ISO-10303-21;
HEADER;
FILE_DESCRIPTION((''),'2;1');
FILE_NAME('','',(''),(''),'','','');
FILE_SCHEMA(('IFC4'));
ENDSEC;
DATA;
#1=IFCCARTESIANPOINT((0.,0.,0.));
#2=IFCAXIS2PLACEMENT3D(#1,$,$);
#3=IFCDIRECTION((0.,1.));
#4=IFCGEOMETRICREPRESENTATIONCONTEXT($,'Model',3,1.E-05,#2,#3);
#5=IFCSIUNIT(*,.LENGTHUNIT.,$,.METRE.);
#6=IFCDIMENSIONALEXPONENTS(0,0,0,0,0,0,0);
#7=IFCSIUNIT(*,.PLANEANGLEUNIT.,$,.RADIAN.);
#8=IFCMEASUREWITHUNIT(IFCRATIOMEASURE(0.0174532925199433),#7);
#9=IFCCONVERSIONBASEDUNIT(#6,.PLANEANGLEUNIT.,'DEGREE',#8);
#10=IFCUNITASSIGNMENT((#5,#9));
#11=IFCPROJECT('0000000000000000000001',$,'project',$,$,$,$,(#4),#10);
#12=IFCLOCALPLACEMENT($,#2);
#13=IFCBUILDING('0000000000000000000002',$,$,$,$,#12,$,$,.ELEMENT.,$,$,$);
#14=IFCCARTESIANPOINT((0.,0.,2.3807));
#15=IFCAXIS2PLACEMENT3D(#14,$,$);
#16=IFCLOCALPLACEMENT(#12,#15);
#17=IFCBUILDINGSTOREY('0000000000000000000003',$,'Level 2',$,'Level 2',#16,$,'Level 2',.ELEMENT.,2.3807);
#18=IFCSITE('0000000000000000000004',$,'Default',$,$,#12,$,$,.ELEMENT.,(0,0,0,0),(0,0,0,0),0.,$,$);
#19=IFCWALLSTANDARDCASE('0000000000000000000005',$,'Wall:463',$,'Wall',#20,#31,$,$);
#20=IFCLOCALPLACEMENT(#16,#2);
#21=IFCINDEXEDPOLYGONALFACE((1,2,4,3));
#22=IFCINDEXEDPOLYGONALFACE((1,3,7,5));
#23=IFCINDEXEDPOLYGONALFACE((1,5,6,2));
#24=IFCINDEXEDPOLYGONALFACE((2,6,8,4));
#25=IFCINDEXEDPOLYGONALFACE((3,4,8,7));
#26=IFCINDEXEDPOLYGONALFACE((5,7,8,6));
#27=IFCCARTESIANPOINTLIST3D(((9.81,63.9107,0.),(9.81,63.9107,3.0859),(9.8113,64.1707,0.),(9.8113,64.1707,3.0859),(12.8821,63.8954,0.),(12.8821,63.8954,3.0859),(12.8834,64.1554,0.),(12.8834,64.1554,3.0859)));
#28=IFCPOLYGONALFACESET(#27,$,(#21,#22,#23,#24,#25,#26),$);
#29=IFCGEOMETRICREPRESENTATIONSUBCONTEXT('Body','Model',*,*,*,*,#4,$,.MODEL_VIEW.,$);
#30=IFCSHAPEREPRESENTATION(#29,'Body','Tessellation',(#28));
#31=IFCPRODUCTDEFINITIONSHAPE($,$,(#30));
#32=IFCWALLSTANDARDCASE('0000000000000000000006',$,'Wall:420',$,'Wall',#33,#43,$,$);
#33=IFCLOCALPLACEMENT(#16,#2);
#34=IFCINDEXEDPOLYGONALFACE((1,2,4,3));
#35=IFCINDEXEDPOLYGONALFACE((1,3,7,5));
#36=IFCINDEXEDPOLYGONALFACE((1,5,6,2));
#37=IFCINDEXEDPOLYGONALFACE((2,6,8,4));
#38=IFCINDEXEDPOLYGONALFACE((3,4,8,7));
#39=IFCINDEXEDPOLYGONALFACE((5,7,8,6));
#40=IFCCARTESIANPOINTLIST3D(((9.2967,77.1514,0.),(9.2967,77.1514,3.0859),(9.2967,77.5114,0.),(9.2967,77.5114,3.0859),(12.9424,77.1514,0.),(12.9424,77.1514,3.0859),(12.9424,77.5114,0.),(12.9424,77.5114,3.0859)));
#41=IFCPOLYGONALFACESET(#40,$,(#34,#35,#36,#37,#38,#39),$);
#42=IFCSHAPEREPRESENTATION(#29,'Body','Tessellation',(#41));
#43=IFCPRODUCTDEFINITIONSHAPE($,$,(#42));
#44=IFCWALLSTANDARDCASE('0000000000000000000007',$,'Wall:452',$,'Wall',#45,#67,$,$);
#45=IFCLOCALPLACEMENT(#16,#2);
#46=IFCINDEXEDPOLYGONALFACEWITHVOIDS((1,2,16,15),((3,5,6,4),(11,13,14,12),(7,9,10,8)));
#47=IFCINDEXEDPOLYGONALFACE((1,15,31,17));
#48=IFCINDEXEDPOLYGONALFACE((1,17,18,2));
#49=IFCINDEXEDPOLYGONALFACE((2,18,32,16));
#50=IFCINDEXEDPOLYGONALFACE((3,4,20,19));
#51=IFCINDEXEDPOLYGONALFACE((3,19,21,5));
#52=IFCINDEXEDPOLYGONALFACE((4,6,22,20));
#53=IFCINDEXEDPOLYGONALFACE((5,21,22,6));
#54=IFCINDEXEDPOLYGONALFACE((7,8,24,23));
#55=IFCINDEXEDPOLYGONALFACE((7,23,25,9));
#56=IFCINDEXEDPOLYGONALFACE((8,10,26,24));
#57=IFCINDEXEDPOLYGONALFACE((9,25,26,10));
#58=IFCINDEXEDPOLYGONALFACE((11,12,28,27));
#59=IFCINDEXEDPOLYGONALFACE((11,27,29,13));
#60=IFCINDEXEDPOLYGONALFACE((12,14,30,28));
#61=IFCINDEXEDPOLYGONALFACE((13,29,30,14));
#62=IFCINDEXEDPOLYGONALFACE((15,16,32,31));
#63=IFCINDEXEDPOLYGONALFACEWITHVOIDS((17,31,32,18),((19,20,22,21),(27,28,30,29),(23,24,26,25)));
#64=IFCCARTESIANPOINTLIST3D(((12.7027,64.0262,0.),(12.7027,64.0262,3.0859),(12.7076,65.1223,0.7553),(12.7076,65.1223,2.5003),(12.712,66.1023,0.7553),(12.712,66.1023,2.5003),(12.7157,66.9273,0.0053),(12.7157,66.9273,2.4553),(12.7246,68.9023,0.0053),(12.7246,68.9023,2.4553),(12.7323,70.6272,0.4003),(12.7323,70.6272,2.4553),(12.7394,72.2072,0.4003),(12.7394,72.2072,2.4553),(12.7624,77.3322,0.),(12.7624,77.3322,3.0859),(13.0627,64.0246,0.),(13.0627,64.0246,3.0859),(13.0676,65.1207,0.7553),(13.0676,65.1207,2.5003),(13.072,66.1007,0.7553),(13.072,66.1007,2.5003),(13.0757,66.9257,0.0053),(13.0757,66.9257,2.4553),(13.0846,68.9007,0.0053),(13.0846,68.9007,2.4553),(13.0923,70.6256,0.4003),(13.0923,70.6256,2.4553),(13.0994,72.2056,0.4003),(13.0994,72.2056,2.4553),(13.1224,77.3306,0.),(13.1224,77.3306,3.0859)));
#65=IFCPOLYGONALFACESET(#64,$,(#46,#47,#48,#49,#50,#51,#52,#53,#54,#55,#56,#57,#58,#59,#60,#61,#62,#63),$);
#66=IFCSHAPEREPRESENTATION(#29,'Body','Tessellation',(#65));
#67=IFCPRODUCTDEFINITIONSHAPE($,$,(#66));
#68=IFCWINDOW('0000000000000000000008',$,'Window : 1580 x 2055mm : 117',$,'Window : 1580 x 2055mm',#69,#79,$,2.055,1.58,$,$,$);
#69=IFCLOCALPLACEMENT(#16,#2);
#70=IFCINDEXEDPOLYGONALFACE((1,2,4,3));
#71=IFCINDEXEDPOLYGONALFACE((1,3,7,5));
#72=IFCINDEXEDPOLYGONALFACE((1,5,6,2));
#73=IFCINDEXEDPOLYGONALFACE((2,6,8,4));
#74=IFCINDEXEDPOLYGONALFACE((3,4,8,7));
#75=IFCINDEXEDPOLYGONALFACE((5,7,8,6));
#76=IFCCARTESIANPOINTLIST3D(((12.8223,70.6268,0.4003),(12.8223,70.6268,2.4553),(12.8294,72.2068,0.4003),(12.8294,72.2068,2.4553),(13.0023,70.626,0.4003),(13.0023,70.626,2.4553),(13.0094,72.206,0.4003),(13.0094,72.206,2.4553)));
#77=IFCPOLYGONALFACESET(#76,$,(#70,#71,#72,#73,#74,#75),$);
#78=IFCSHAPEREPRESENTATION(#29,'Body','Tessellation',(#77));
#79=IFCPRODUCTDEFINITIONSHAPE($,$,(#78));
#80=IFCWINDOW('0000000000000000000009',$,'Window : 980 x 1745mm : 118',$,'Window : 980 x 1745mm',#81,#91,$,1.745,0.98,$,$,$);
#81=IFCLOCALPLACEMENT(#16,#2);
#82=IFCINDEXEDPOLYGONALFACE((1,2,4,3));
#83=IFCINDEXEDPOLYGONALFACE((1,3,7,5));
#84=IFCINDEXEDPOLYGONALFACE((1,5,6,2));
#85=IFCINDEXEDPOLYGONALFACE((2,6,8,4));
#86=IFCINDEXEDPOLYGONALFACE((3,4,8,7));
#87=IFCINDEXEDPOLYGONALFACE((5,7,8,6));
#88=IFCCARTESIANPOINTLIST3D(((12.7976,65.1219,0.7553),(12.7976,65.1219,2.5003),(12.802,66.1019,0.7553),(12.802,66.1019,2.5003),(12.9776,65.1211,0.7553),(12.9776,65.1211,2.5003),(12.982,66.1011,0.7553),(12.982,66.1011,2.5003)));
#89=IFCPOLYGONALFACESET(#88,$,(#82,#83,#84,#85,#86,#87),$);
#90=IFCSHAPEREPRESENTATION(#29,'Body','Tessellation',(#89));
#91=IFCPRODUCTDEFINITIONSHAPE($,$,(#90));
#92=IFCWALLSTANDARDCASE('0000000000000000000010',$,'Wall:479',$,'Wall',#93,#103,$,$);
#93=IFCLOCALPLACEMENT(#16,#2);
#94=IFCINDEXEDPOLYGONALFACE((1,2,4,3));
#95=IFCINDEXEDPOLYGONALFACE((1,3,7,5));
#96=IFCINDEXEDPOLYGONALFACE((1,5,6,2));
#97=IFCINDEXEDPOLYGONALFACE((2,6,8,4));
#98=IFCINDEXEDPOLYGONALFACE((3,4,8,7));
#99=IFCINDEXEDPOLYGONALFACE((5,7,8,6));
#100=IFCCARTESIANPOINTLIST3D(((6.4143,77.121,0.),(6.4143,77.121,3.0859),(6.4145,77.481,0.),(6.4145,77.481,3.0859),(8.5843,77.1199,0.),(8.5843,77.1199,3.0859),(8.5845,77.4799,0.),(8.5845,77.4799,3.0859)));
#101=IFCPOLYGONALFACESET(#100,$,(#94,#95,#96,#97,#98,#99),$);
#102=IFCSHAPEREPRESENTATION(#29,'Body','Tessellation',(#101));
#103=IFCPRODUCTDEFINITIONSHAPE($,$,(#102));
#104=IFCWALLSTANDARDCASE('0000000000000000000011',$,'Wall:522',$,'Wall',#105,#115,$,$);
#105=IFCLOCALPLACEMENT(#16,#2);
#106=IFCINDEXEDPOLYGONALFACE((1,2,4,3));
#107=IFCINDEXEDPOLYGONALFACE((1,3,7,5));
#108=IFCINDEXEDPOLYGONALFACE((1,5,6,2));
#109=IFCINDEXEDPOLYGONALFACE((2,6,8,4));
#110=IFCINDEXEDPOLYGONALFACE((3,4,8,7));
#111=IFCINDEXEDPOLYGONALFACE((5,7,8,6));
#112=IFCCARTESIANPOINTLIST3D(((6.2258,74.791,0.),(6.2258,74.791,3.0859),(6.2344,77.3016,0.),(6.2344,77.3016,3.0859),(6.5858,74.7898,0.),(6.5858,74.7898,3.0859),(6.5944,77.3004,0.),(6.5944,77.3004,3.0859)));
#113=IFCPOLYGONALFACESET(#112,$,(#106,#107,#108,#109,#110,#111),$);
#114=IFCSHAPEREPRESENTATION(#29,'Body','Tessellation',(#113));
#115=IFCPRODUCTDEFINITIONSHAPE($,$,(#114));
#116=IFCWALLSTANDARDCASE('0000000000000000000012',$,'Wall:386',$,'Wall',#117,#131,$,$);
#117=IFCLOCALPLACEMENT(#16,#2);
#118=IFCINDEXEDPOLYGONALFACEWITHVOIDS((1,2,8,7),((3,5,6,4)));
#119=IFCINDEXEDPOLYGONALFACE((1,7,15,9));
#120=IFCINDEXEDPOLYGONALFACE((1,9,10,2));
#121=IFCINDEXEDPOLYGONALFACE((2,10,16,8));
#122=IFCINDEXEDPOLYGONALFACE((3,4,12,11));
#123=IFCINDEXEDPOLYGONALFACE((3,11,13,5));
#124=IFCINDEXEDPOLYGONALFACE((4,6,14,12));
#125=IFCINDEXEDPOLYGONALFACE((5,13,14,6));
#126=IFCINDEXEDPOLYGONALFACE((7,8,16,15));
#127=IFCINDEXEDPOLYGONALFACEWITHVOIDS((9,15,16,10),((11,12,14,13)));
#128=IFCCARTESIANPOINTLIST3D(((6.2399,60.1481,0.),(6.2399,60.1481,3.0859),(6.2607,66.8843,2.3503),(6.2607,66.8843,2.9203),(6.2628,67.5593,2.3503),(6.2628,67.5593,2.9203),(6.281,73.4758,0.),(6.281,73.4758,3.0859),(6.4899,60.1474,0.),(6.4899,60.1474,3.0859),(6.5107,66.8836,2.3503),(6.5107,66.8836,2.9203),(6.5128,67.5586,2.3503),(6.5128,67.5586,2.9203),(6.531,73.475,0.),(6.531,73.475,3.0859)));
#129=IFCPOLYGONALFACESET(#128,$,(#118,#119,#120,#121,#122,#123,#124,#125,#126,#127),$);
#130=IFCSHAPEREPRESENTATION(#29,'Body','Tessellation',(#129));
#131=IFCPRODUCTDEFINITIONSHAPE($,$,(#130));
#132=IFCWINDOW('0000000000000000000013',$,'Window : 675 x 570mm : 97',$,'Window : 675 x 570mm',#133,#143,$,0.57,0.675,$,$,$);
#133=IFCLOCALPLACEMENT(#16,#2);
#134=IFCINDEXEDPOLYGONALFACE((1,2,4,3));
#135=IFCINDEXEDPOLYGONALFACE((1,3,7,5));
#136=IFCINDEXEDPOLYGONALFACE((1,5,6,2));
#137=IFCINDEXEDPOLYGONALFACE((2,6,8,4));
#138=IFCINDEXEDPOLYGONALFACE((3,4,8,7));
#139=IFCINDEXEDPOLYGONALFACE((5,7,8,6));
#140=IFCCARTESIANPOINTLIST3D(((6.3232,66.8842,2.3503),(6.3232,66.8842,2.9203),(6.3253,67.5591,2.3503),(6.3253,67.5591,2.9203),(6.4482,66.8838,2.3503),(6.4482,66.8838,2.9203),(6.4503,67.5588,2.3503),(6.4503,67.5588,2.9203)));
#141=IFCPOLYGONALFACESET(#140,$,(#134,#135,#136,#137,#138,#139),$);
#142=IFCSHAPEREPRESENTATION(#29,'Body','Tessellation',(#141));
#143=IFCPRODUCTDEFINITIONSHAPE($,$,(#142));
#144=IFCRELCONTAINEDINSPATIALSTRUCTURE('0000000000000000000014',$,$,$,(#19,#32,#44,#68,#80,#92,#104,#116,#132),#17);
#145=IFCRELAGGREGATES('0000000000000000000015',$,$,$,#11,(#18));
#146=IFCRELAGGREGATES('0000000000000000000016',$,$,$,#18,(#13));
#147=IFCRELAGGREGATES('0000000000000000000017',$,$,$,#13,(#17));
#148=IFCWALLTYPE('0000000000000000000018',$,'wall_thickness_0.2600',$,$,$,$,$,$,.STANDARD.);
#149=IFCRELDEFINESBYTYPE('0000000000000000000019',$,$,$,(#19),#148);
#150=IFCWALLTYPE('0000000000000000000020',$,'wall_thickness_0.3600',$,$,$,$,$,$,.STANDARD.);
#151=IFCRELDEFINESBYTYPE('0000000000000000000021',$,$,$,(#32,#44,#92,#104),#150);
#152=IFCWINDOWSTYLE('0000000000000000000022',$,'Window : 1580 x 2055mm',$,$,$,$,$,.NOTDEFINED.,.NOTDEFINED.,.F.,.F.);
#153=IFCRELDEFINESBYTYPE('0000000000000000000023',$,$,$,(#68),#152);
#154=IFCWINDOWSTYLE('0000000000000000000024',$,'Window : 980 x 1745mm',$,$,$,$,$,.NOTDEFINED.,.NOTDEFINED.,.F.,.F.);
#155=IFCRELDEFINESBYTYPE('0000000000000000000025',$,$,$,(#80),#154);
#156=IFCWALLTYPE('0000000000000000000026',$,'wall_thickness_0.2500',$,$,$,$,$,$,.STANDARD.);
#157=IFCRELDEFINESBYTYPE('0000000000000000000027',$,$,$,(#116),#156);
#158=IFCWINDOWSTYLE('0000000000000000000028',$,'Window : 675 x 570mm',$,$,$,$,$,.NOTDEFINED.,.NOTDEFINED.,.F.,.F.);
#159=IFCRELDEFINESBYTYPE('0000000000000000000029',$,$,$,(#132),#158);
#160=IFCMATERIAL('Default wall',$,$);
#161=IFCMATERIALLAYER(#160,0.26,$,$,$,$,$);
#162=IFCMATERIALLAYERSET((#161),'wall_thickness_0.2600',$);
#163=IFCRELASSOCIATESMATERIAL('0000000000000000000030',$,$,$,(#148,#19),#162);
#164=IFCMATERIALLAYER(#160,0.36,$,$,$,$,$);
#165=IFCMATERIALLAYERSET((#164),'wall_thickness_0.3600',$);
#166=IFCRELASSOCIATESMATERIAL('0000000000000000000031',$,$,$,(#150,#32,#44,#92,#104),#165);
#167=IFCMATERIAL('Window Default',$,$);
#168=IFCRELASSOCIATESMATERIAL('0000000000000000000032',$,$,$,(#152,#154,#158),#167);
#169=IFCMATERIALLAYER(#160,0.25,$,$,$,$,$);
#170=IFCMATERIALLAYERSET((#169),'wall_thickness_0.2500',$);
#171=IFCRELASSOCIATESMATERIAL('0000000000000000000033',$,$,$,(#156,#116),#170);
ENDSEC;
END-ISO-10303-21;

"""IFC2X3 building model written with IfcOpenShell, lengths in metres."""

from ifc_helpers import new_model, entity, si_unit, converted_unit, direction, frame, frame_2d, origin, origin_2d_with_axis, place, context, subcontext, project, spatial, polyline, rectangle, outline, extrude, source, transform, mapped, material, layer, layer_set, layer_usage, type_object, type_shapes, element, fill, save


model = new_model("IFC2X3")

# Units and contexts
model_context = context("Model", 3, precision=1e-05, world=origin(), true_north=direction((0.0, 1.0)))
body_context = subcontext(model_context, "Body", "Model", "MODEL_VIEW")
ifc_project = project(units=[si_unit("LENGTHUNIT", "METRE"), converted_unit("PLANEANGLEUNIT", "DEGREE", entity("IfcRatioMeasure", 0.0174532925199433), si_unit("PLANEANGLEUNIT", "RADIAN"), dimensions=[0, 0, 0, 0, 0, 0, 0])], contexts=[model_context])

# Site, building, storey
placement_1 = place(None, origin())
site = spatial("IfcSite", under=ifc_project, at=placement_1, Name="Default", CompositionType="ELEMENT", RefLatitude=(0, 0, 0, 0), RefLongitude=(0, 0, 0, 0), RefElevation=0.0)
building = spatial("IfcBuilding", under=site, at=placement_1, CompositionType="ELEMENT")
storey_placement = place(placement_1, frame((0.0, 0.0, 2.3807)))
storey = spatial("IfcBuildingStorey", under=building, at=storey_placement, Name="Level 2", ObjectType="Level 2", LongName="Level 2", CompositionType="ELEMENT", Elevation=2.3807)

# Walls
ifc_material_1 = material(Name="Default wall")
ifc_layer_1 = layer(ifc_material_1, 0.26)
ifc_layer_set_1 = layer_set([ifc_layer_1], Name="wall_thickness_0.2600")
ifc_layer_usage_1 = layer_usage(ifc_layer_set_1, "AXIS2", "POSITIVE", -0.13)
wall_type_1 = type_object("IfcWallType", Name="wall_thickness_0.2600", PredefinedType="STANDARD", material=ifc_layer_set_1)
wall_1_placement = place(storey_placement, frame((9.8107, 64.0407, 0.0), z_axis=(0.0, 0.0, 1.0), x_axis=(0.999988, -0.004987, 0.0)))
element("IfcWallStandardCase", 1, at=wall_1_placement, inside=storey, type_object=wall_type_1, material=ifc_layer_usage_1, Name="Wall:463", ObjectType="Wall", context=body_context, shape_type="SweptSolid", body=[
    extrude(outline(polyline([(3.0721, -0.13), (3.0721, 0.13), (0.0, 0.13), (0.0, -0.13), (3.0721, -0.13)])), origin(), (0.0, 0.0, 1.0), 3.0859),
])
ifc_layer_2 = layer(ifc_material_1, 0.36)
ifc_layer_set_2 = layer_set([ifc_layer_2], Name="wall_thickness_0.3600")
ifc_layer_usage_2 = layer_usage(ifc_layer_set_2, "AXIS2", "POSITIVE", -0.18)
wall_type_2 = type_object("IfcWallType", Name="wall_thickness_0.3600", PredefinedType="STANDARD", material=ifc_layer_set_2)
wall_2_placement = place(storey_placement, frame((9.2967, 77.3314, 0.0), z_axis=(0.0, 0.0, 1.0), x_axis=(1.0, 0.0, 0.0)))
element("IfcWallStandardCase", 2, at=wall_2_placement, inside=storey, type_object=wall_type_2, material=ifc_layer_usage_2, Name="Wall:420", ObjectType="Wall", context=body_context, shape_type="SweptSolid", body=[
    extrude(outline(polyline([(3.6458, -0.18), (3.6458, 0.18), (0.0, 0.18), (0.0, -0.18), (3.6458, -0.18)])), origin(), (0.0, 0.0, 1.0), 3.0859),
])

# Wall, openings, windows
wall_3_placement = place(storey_placement, frame((12.9424, 77.3314, 0.0), z_axis=(0.0, 0.0, 1.0), x_axis=(-0.004488, -0.99999, 0.0)))
wall_3 = element("IfcWallStandardCase", 3, at=wall_3_placement, inside=storey, type_object=wall_type_2, material=ifc_layer_usage_2, Name="Wall:452", ObjectType="Wall", context=body_context, shape_type="SweptSolid", body=[
    extrude(outline(polyline([(13.3062, -0.18), (13.3062, 0.18), (0.0, 0.18), (0.0, -0.18), (13.3062, -0.18)])), origin(), (0.0, 0.0, 1.0), 3.0859),
])
opening_1_placement = place(wall_3_placement, frame((8.4301, -0.18, 0.0053)))
element("IfcOpeningElement", 4, at=opening_1_placement, cuts=wall_3, ObjectType="Opening", context=body_context, shape_type="SweptSolid", body=[
    extrude(rectangle(XDim=1.975, YDim=2.45, at=frame_2d((1.225, 0.9875), x_axis=(0.0, 1.0))), frame((0.0, 0.0, 0.0), z_axis=(0.0, 1.0, 0.0), x_axis=(0.0, 0.0, 1.0)), (0.0, 0.0, 1.0), 0.36),
])
opening_2_placement = place(wall_3_placement, frame((5.1251, -0.18, 0.4003)))
opening_2 = element("IfcOpeningElement", 5, at=opening_2_placement, cuts=wall_3, ObjectType="Opening", context=body_context, shape_type="SweptSolid", body=[
    extrude(rectangle(XDim=1.58, YDim=2.055, at=frame_2d((1.0275, 0.79), x_axis=(0.0, 1.0))), frame((0.0, 0.0, 0.0), z_axis=(0.0, 1.0, 0.0), x_axis=(0.0, 0.0, 1.0)), (0.0, 0.0, 1.0), 0.36),
])
opening_3_placement = place(wall_3_placement, frame((11.2301, -0.18, 0.7553)))
opening_3 = element("IfcOpeningElement", 6, at=opening_3_placement, cuts=wall_3, ObjectType="Opening", context=body_context, shape_type="SweptSolid", body=[
    extrude(rectangle(XDim=0.98, YDim=1.745, at=frame_2d((0.8725, 0.49), x_axis=(0.0, 1.0))), frame((0.0, 0.0, 0.0), z_axis=(0.0, 1.0, 0.0), x_axis=(0.0, 0.0, 1.0)), (0.0, 0.0, 1.0), 0.36),
])
ifc_material_2 = material(Name="Window Default")
window_style_1 = type_object("IfcWindowStyle", Name="Window : 1580 x 2055mm", ConstructionType="NOTDEFINED", OperationType="NOTDEFINED", ParameterTakesPrecedence=False, Sizeable=False, material=ifc_material_2)
shared_shape_1 = source(origin(), body_context, "Body", "SweptSolid", [
    extrude(rectangle(XDim=0.18, YDim=1.58, at=origin_2d_with_axis()), frame((0.79, 0.18, 0.0), z_axis=(0.0, 0.0, 1.0), x_axis=(0.0, 1.0, 0.0)), (0.0, 0.0, 1.0), 2.055),
])
type_shapes(window_style_1, [shared_shape_1])
window_1_placement = place(opening_2_placement, origin())
window_1 = element("IfcWindow", 7, at=window_1_placement, inside=storey, type_object=window_style_1, Name="Window : 1580 x 2055mm : 117", ObjectType="Window : 1580 x 2055mm", OverallHeight=2.055, OverallWidth=1.58, context=body_context, shape_type="MappedRepresentation", body=[
    mapped(shared_shape_1, transform((0.0, 0.0, 0.0), scale=1.0)),
])
fill(opening_2, window_1)
window_style_2 = type_object("IfcWindowStyle", Name="Window : 980 x 1745mm", ConstructionType="NOTDEFINED", OperationType="NOTDEFINED", ParameterTakesPrecedence=False, Sizeable=False, material=ifc_material_2)
shared_shape_2 = source(origin(), body_context, "Body", "SweptSolid", [
    extrude(rectangle(XDim=0.18, YDim=0.98, at=origin_2d_with_axis()), frame((0.49, 0.18, 0.0), z_axis=(0.0, 0.0, 1.0), x_axis=(0.0, 1.0, 0.0)), (0.0, 0.0, 1.0), 1.745),
])
type_shapes(window_style_2, [shared_shape_2])
window_2_placement = place(opening_3_placement, origin())
window_2 = element("IfcWindow", 8, at=window_2_placement, inside=storey, type_object=window_style_2, Name="Window : 980 x 1745mm : 118", ObjectType="Window : 980 x 1745mm", OverallHeight=1.745, OverallWidth=0.98, context=body_context, shape_type="MappedRepresentation", body=[
    mapped(shared_shape_2, transform((0.0, 0.0, 0.0), scale=1.0)),
])
fill(opening_3, window_2)

# Walls
wall_4_placement = place(storey_placement, frame((6.4144, 77.301, 0.0), z_axis=(0.0, 0.0, 1.0), x_axis=(1.0, -0.000499, 0.0)))
element("IfcWallStandardCase", 9, at=wall_4_placement, inside=storey, type_object=wall_type_2, material=ifc_layer_usage_2, Name="Wall:479", ObjectType="Wall", context=body_context, shape_type="SweptSolid", body=[
    extrude(outline(polyline([(2.17, -0.18), (2.17, 0.18), (0.0, 0.18), (0.0, -0.18), (2.17, -0.18)])), origin(), (0.0, 0.0, 1.0), 3.0859),
])
wall_5_placement = place(storey_placement, frame((6.4144, 77.301, 0.0), z_axis=(0.0, 0.0, 1.0), x_axis=(-0.003432, -0.999994, 0.0)))
element("IfcWallStandardCase", 10, at=wall_5_placement, inside=storey, type_object=wall_type_2, material=ifc_layer_usage_2, Name="Wall:522", ObjectType="Wall", context=body_context, shape_type="SweptSolid", body=[
    extrude(outline(polyline([(2.5106, -0.18), (2.5106, 0.18), (0.0, 0.18), (0.0, -0.18), (2.5106, -0.18)])), origin(), (0.0, 0.0, 1.0), 3.0859),
])

# Wall, opening, window
ifc_layer_3 = layer(ifc_material_1, 0.25)
ifc_layer_set_3 = layer_set([ifc_layer_3], Name="wall_thickness_0.2500")
ifc_layer_usage_3 = layer_usage(ifc_layer_set_3, "AXIS2", "POSITIVE", -0.125)
wall_type_3 = type_object("IfcWallType", Name="wall_thickness_0.2500", PredefinedType="STANDARD", material=ifc_layer_set_3)
wall_6_placement = place(storey_placement, frame((6.406, 73.4754, 0.0), z_axis=(0.0, 0.0, 1.0), x_axis=(-0.003085, -0.999995, 0.0)))
wall_6 = element("IfcWallStandardCase", 11, at=wall_6_placement, inside=storey, type_object=wall_type_3, material=ifc_layer_usage_3, Name="Wall:386", ObjectType="Wall", context=body_context, shape_type="SweptSolid", body=[
    extrude(outline(polyline([(13.3277, -0.125), (13.3277, 0.125), (0.0, 0.125), (0.0, -0.125), (13.3277, -0.125)])), origin(), (0.0, 0.0, 1.0), 3.0859),
])
opening_4_placement = place(wall_6_placement, frame((5.9164, -0.125, 2.3503)))
opening_4 = element("IfcOpeningElement", 12, at=opening_4_placement, cuts=wall_6, ObjectType="Opening", context=body_context, shape_type="SweptSolid", body=[
    extrude(rectangle(XDim=0.675, YDim=0.57, at=frame_2d((0.285, 0.3375), x_axis=(0.0, 1.0))), frame((0.0, 0.0, 0.0), z_axis=(0.0, 1.0, 0.0), x_axis=(0.0, 0.0, 1.0)), (0.0, 0.0, 1.0), 0.25),
])
window_style_3 = type_object("IfcWindowStyle", Name="Window : 675 x 570mm", ConstructionType="NOTDEFINED", OperationType="NOTDEFINED", ParameterTakesPrecedence=False, Sizeable=False, material=ifc_material_2)
shared_shape_3 = source(origin(), body_context, "Body", "SweptSolid", [
    extrude(rectangle(XDim=0.125, YDim=0.675, at=origin_2d_with_axis()), frame((0.3375, 0.125, 0.0), z_axis=(0.0, 0.0, 1.0), x_axis=(0.0, 1.0, 0.0)), (0.0, 0.0, 1.0), 0.57),
])
type_shapes(window_style_3, [shared_shape_3])
window_3_placement = place(opening_4_placement, origin())
window_3 = element("IfcWindow", 13, at=window_3_placement, inside=storey, type_object=window_style_3, Name="Window : 675 x 570mm : 97", ObjectType="Window : 675 x 570mm", OverallHeight=0.57, OverallWidth=0.675, context=body_context, shape_type="MappedRepresentation", body=[
    mapped(shared_shape_3, transform((0.0, 0.0, 0.0), scale=1.0)),
])
fill(opening_4, window_3)

save(model, "model.ifc")
